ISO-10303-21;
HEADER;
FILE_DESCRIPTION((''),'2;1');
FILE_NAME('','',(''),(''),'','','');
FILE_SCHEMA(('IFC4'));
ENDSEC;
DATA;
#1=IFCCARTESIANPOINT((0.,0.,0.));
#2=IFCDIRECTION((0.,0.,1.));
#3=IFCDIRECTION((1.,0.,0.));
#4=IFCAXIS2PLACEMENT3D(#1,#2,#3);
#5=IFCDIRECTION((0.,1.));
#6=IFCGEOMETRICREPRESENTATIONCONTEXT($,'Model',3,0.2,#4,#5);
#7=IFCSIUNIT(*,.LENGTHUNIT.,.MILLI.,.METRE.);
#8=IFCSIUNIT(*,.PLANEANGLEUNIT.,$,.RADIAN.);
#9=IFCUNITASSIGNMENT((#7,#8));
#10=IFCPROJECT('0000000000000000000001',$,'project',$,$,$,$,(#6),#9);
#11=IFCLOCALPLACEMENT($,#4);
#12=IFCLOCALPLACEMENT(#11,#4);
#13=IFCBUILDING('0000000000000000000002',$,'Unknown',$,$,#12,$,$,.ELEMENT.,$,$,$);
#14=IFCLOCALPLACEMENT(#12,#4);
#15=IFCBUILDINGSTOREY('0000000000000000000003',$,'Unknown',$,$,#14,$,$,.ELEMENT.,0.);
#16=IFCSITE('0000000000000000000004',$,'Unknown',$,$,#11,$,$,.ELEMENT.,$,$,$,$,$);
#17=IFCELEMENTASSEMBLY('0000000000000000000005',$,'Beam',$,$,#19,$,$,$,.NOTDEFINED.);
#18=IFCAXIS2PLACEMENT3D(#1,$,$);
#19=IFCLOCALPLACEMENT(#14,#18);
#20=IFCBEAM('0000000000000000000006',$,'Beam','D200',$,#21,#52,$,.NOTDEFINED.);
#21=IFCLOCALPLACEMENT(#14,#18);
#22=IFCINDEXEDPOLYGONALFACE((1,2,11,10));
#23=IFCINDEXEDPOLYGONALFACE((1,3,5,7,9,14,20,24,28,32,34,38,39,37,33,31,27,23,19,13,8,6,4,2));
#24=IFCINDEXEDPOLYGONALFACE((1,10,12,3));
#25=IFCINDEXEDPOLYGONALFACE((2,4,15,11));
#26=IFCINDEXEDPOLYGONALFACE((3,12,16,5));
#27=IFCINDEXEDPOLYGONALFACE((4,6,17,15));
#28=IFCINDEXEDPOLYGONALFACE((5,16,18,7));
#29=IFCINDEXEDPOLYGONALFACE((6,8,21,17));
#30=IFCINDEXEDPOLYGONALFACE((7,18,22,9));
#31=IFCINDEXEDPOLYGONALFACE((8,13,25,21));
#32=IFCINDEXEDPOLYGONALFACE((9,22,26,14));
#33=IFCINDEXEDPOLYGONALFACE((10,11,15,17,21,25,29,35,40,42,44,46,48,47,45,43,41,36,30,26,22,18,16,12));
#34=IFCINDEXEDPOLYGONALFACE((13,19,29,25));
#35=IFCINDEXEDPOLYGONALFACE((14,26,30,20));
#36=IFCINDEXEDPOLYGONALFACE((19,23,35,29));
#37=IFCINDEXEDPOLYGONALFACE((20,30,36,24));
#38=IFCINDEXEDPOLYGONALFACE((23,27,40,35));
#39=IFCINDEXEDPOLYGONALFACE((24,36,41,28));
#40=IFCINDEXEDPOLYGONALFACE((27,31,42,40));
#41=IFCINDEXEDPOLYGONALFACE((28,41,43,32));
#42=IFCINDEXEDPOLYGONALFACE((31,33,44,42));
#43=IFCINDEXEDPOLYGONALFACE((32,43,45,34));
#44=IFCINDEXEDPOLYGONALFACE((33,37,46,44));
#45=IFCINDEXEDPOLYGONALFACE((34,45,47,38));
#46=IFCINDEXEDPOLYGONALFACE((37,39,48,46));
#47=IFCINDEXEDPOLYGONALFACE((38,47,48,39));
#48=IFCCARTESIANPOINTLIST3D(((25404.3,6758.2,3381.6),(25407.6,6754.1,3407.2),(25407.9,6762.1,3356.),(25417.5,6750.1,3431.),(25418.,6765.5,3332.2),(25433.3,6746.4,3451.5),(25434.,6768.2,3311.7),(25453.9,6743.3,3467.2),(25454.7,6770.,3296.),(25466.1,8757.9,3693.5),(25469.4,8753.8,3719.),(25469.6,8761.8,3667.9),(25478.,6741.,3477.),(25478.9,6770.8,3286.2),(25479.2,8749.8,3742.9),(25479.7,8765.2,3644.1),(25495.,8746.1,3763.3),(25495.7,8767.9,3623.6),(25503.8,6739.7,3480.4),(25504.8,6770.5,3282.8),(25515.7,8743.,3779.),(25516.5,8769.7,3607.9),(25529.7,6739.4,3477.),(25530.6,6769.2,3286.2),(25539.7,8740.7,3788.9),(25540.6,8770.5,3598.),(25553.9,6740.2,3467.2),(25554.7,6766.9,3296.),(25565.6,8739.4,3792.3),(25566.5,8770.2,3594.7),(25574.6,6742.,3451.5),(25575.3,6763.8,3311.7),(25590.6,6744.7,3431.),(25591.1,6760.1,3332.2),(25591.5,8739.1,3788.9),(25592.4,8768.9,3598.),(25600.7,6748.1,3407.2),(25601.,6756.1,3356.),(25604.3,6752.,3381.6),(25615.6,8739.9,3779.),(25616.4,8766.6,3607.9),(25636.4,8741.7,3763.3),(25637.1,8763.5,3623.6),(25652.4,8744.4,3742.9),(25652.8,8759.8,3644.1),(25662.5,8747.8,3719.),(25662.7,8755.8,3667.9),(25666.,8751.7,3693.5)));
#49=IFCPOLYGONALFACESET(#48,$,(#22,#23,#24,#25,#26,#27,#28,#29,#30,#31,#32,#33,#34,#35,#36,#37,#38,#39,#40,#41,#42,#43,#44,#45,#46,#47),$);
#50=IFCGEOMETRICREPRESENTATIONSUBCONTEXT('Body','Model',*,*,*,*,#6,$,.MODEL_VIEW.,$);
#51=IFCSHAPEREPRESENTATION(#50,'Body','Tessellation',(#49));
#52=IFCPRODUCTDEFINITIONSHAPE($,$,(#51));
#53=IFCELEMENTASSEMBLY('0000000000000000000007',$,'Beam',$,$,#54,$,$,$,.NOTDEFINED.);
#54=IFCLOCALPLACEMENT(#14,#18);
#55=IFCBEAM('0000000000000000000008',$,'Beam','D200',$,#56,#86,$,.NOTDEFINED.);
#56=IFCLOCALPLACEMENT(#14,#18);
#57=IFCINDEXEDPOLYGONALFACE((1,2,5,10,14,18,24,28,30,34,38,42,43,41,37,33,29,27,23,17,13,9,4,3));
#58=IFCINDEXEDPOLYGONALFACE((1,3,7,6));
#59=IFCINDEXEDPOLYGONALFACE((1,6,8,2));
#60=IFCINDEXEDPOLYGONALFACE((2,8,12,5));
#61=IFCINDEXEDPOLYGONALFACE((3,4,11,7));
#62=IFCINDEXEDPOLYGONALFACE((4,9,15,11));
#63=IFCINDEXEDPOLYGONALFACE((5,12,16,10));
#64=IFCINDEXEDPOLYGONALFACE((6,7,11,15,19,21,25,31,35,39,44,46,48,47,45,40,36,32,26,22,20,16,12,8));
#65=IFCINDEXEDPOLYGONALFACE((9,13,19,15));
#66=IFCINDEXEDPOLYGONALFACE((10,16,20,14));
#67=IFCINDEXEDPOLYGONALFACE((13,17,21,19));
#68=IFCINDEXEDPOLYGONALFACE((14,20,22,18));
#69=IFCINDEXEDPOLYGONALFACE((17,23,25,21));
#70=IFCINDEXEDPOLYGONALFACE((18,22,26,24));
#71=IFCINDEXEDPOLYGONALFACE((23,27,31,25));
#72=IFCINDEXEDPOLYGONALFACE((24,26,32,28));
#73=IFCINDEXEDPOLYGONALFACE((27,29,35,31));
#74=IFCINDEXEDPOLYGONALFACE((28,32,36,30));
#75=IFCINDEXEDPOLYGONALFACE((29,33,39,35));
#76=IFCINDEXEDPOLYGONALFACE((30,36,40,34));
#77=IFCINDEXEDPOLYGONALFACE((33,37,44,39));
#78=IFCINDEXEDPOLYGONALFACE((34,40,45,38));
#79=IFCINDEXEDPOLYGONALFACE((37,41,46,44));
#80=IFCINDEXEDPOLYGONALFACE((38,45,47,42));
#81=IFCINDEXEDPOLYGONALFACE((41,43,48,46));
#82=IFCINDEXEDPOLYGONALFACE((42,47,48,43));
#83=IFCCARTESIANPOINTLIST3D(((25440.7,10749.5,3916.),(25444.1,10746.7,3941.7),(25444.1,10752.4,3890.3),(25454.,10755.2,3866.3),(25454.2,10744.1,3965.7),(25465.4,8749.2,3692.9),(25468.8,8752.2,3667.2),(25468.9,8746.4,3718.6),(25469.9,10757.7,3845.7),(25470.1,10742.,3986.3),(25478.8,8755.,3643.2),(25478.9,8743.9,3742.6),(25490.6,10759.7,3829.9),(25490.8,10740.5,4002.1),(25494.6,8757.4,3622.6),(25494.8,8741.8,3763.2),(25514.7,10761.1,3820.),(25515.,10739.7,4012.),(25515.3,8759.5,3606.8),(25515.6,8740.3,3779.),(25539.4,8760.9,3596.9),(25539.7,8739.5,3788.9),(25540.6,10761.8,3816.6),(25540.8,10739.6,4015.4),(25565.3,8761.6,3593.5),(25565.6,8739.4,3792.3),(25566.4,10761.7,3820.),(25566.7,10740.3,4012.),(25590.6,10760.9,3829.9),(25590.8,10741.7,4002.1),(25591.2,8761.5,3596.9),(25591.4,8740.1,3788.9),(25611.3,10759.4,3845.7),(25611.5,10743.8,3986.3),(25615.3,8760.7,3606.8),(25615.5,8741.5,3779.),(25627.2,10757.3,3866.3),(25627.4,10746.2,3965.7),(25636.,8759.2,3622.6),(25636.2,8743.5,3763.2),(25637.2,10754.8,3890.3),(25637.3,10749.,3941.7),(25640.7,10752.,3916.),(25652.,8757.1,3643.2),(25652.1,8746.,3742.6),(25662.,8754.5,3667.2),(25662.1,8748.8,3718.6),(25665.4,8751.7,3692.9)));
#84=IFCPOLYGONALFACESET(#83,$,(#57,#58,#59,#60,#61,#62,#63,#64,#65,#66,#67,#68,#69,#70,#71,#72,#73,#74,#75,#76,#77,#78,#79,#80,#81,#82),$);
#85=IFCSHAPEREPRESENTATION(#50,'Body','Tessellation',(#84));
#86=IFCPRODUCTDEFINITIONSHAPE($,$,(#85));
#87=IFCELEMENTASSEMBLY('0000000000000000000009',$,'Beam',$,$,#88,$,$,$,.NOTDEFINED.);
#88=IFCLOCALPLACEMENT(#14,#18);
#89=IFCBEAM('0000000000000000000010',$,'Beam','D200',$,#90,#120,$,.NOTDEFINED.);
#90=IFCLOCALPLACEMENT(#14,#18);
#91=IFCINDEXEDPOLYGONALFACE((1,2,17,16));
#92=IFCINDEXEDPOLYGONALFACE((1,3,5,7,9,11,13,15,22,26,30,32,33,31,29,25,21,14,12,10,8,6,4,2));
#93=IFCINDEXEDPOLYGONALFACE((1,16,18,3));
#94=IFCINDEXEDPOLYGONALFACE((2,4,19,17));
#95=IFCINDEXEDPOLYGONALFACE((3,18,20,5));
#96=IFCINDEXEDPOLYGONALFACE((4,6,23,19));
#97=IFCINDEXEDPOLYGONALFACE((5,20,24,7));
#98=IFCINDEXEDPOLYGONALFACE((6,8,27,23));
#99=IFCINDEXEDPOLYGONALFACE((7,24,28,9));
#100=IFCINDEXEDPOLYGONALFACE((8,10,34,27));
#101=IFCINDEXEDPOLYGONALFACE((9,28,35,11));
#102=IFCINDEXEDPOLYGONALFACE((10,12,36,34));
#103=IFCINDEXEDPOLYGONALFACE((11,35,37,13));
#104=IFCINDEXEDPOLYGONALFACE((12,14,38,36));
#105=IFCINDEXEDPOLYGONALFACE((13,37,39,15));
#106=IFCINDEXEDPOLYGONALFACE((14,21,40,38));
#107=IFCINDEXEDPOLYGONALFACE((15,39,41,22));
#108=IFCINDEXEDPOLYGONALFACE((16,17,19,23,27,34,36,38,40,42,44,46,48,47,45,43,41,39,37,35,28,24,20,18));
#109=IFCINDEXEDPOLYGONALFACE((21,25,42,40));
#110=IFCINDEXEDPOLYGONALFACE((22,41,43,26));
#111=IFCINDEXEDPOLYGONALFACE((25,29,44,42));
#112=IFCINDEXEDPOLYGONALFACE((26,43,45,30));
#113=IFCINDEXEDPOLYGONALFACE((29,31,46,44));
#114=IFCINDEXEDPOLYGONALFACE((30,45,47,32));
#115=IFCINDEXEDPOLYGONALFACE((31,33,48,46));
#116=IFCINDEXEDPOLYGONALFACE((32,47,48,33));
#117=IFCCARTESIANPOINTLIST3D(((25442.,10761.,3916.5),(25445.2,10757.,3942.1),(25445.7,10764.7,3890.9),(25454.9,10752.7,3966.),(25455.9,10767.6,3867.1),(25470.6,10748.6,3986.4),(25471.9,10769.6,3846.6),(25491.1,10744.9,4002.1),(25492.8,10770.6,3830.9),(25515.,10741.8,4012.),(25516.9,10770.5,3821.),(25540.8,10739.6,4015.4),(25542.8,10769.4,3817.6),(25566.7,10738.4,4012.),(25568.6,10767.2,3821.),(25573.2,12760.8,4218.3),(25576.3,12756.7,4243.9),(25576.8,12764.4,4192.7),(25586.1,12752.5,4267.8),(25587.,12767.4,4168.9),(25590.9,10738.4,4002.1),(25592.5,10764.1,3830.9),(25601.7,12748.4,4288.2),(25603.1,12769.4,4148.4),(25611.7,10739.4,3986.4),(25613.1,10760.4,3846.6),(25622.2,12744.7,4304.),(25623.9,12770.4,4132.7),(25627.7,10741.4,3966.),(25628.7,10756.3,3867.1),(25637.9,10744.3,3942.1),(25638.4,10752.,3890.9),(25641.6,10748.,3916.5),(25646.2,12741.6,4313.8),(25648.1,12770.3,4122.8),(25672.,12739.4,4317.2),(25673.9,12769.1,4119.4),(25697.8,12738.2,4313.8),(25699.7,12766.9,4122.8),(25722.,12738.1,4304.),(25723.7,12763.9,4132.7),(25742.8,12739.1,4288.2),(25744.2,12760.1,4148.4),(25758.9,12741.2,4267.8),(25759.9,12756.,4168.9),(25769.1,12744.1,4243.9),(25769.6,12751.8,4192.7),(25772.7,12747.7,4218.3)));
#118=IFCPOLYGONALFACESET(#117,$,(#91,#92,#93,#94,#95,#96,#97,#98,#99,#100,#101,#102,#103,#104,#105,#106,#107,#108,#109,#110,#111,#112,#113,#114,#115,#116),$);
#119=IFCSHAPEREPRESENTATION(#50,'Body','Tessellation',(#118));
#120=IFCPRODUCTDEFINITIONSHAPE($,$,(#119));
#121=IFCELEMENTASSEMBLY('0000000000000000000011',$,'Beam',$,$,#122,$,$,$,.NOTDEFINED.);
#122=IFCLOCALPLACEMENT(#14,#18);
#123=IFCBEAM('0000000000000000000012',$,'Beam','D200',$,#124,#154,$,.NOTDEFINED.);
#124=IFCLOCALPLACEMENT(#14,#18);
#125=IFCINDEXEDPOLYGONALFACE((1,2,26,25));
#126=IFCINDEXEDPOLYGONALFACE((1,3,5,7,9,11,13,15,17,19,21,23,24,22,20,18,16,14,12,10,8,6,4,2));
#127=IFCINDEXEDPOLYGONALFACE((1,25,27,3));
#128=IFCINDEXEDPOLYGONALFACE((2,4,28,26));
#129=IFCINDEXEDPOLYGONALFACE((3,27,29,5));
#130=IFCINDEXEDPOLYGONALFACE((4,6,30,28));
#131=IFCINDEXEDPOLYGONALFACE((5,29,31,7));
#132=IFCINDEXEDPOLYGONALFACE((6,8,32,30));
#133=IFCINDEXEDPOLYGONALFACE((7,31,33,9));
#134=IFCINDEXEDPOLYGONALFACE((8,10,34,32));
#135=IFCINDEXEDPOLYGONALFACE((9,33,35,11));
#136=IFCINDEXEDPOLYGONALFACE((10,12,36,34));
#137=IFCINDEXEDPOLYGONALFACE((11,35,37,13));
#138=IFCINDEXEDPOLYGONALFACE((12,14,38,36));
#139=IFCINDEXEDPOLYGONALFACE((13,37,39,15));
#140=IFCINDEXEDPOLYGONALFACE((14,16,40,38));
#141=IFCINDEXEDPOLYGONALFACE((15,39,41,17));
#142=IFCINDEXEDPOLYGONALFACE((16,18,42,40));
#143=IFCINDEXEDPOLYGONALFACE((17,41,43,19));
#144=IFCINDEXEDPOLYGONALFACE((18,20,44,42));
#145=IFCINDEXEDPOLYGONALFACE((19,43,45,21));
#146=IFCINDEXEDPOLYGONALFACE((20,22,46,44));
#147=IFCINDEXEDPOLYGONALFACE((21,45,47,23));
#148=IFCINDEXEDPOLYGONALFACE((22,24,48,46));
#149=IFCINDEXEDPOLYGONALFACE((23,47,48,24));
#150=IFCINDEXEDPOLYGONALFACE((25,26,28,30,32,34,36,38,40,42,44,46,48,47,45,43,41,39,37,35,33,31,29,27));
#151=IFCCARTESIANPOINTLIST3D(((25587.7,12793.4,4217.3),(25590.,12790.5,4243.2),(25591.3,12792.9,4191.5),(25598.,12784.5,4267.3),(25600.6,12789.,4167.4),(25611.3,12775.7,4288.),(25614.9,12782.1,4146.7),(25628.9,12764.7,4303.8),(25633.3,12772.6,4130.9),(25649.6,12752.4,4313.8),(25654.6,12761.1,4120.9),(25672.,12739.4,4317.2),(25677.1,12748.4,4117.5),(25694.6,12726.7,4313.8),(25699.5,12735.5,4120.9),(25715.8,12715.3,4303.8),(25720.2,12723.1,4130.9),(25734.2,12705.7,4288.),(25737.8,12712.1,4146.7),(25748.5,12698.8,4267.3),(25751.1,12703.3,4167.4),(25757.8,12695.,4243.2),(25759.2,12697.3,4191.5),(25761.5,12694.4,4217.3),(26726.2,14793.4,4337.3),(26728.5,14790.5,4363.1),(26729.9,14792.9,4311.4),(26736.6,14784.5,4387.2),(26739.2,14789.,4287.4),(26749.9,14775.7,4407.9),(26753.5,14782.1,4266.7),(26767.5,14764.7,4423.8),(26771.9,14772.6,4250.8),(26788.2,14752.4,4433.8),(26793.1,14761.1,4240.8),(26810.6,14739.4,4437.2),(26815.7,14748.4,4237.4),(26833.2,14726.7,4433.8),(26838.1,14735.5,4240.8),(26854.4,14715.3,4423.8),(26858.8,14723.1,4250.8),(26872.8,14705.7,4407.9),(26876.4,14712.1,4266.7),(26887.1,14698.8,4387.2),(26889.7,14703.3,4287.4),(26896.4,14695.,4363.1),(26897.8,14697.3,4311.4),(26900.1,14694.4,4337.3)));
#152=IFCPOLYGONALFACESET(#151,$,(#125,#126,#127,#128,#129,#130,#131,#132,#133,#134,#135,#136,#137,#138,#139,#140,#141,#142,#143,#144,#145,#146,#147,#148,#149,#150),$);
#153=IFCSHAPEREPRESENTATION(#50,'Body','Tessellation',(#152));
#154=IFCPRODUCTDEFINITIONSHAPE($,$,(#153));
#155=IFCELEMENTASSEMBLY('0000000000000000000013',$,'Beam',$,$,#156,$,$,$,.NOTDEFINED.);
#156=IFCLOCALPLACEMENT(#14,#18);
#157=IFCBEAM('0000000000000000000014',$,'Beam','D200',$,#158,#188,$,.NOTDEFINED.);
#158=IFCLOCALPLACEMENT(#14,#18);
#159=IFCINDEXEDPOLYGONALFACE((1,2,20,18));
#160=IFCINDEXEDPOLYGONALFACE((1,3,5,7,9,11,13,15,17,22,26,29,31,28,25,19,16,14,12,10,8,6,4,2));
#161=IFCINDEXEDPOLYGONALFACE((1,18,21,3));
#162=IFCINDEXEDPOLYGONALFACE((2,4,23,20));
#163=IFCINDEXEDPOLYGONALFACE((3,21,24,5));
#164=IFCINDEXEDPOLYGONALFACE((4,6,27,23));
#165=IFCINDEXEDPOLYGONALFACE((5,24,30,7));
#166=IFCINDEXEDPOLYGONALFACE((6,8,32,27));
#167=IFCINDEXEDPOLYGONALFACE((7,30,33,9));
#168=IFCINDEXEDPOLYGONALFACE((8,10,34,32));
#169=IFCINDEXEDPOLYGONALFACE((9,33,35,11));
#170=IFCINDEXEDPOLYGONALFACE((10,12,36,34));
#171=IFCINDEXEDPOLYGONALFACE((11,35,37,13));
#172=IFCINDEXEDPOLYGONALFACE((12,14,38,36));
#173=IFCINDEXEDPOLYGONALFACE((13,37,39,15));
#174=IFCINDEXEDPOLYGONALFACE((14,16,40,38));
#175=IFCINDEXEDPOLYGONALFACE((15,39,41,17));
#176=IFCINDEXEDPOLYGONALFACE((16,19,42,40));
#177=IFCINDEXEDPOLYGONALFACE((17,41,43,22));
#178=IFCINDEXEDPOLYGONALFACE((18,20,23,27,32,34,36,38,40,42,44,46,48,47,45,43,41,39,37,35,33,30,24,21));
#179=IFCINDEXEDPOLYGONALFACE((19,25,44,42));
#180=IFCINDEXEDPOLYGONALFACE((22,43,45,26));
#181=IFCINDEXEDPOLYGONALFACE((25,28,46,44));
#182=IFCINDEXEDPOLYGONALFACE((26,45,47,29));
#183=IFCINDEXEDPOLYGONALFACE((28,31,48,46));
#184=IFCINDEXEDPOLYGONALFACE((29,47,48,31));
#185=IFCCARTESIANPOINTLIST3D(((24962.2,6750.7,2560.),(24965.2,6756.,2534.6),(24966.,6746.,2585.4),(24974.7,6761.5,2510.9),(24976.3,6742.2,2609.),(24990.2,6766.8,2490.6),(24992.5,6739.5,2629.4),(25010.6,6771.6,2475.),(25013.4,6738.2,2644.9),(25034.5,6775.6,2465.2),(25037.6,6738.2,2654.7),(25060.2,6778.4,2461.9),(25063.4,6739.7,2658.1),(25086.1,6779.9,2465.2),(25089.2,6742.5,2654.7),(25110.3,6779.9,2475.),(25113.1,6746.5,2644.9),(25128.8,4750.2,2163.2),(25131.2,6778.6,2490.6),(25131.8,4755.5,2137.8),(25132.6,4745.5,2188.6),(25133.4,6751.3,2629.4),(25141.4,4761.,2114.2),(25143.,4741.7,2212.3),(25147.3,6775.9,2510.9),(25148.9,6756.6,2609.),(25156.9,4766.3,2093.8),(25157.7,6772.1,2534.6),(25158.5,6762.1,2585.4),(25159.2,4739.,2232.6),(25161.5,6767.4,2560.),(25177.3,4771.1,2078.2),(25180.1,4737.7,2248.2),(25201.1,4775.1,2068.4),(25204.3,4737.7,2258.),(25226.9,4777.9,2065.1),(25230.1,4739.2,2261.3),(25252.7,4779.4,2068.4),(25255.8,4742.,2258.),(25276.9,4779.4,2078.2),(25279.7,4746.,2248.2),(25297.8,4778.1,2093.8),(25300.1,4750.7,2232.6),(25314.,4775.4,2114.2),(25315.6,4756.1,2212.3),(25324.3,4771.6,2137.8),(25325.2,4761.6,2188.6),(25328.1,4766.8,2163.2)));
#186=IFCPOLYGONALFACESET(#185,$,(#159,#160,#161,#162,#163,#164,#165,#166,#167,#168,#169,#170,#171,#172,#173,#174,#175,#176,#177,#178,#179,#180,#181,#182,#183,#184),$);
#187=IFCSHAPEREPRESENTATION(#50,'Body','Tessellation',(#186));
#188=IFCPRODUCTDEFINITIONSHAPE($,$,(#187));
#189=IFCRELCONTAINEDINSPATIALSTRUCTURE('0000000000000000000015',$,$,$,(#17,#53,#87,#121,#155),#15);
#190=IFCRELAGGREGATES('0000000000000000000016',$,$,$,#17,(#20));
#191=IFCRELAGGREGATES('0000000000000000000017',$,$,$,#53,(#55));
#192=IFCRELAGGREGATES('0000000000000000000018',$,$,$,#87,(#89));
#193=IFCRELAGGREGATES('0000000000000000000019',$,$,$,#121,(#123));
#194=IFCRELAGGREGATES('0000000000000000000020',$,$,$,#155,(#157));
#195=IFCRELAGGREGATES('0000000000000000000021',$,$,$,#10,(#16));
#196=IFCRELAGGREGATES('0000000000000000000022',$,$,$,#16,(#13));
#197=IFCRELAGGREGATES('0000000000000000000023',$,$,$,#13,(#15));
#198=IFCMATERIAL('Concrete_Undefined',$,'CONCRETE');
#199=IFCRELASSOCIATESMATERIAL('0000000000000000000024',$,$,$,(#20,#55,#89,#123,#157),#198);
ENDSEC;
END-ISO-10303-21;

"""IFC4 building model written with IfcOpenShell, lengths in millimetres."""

from ifc_helpers import new_model, si_unit, direction, frame, origin_with_axes, place, context, subcontext, project, spatial, line, indexed_curve, outline, extrude, material, element, aggregate, save


model = new_model("IFC4")

# Units and contexts
model_context = context("Model", 3, precision=0.2, world=origin_with_axes(), true_north=direction((0.0, 1.0)))
body_context = subcontext(model_context, "Body", "Model", "MODEL_VIEW")
ifc_project = project(units=[si_unit("LENGTHUNIT", "METRE", prefix="MILLI"), si_unit("PLANEANGLEUNIT", "RADIAN")], contexts=[model_context])

# Site, building, storey
site_placement = place(None, origin_with_axes())
site = spatial("IfcSite", under=ifc_project, at=site_placement, Name="Unknown", CompositionType="ELEMENT")
building_placement = place(site_placement, origin_with_axes())
building = spatial("IfcBuilding", under=site, at=building_placement, Name="Unknown", CompositionType="ELEMENT")
storey_placement = place(building_placement, origin_with_axes())
storey = spatial("IfcBuildingStorey", under=building, at=storey_placement, Name="Unknown", CompositionType="ELEMENT", Elevation=0.0)

# Shared definitions
ifc_material = material(Name="Concrete_Undefined", Category="CONCRETE")

# Element assemblies, beams
assembly_1_placement = place(storey_placement, frame((25566.0, 8754.8, 3693.5), z_axis=(-0.999524, 0.030862, 0.0), x_axis=(-0.030494, -0.987596, -0.154025)))
assembly_1 = element("IfcElementAssembly", 1, at=assembly_1_placement, inside=storey, Name="Beam", PredefinedType="NOTDEFINED")
beam_1_placement = place(assembly_1_placement, origin_with_axes())
beam_1 = element("IfcBeam", 2, at=beam_1_placement, material=ifc_material, Name="Beam", Description="D200", PredefinedType="NOTDEFINED", context=body_context, shape_type="SolidModel", body=[
    extrude(outline(indexed_curve([(100.0, 0.0), (96.6, 25.9), (86.6, 50.0), (70.7, 70.7), (50.0, 86.6), (25.9, 96.6), (0.0, 100.0), (-25.9, 96.6), (-50.0, 86.6), (-70.7, 70.7), (-86.6, 50.0), (-96.6, 25.9), (-100.0, 0.0), (-96.6, -25.9), (-86.6, -50.0), (-70.7, -70.7), (-50.0, -86.6), (-25.9, -96.6), (0.0, -100.0), (25.9, -96.6), (50.0, -86.6), (70.7, -70.7), (86.6, -50.0), (96.6, -25.9)], segments=[line(1, 2, 3, 4, 5, 6, 7, 8, 9, 10, 11, 12, 13, 14, 15, 16, 17, 18, 19, 20, 21, 22, 23, 24, 1)])), frame((0.0, 0.0, 0.0), z_axis=(-1.0, 0.0, 0.0), x_axis=(0.0, 0.0, 1.0)), (0.0, 0.0, -1.0), 2024.8),
])
aggregate(assembly_1, [beam_1])
assembly_2_placement = place(storey_placement, frame((25540.7, 10750.7, 3916.0), z_axis=(-0.999924, -0.012364, 0.0), x_axis=(0.012288, -0.993761, -0.110851)))
assembly_2 = element("IfcElementAssembly", 3, at=assembly_2_placement, inside=storey, Name="Beam", PredefinedType="NOTDEFINED")
beam_2_placement = place(assembly_2_placement, origin_with_axes())
beam_2 = element("IfcBeam", 4, at=beam_2_placement, material=ifc_material, Name="Beam", Description="D200", PredefinedType="NOTDEFINED", context=body_context, shape_type="SolidModel", body=[
    extrude(outline(indexed_curve([(100.0, 0.0), (96.6, 25.9), (86.6, 50.0), (70.7, 70.7), (50.0, 86.6), (25.9, 96.6), (0.0, 100.0), (-25.9, 96.6), (-50.0, 86.6), (-70.7, 70.7), (-86.6, 50.0), (-96.6, 25.9), (-100.0, 0.0), (-96.6, -25.9), (-86.6, -50.0), (-70.7, -70.7), (-50.0, -86.6), (-25.9, -96.6), (0.0, -100.0), (25.9, -96.6), (50.0, -86.6), (70.7, -70.7), (86.6, -50.0), (96.6, -25.9)], segments=[line(1, 2, 3, 4, 5, 6, 7, 8, 9, 10, 11, 12, 13, 14, 15, 16, 17, 18, 19, 20, 21, 22, 23, 24, 1)])), frame((0.0, 0.0, 0.0), z_axis=(-1.0, 0.0, 0.0), x_axis=(0.0, 0.0, 1.0)), (0.0, 0.0, -1.0), 2012.8),
])
aggregate(assembly_2, [beam_2])
assembly_3_placement = place(storey_placement, frame((25673.0, 12754.3, 4218.3), z_axis=(-0.997856, 0.065442, 0.0), x_axis=(-0.064712, -0.986729, -0.148924)))
assembly_3 = element("IfcElementAssembly", 5, at=assembly_3_placement, inside=storey, Name="Beam", PredefinedType="NOTDEFINED")
beam_3_placement = place(assembly_3_placement, origin_with_axes())
beam_3 = element("IfcBeam", 6, at=beam_3_placement, material=ifc_material, Name="Beam", Description="D200", PredefinedType="NOTDEFINED", context=body_context, shape_type="SolidModel", body=[
    extrude(outline(indexed_curve([(100.0, 0.0), (96.6, 25.9), (86.6, 50.0), (70.7, 70.7), (50.0, 86.6), (25.9, 96.6), (0.0, 100.0), (-25.9, 96.6), (-50.0, 86.6), (-70.7, 70.7), (-86.6, 50.0), (-96.6, 25.9), (-100.0, 0.0), (-96.6, -25.9), (-86.6, -50.0), (-70.7, -70.7), (-50.0, -86.6), (-25.9, -96.6), (0.0, -100.0), (25.9, -96.6), (50.0, -86.6), (70.7, -70.7), (86.6, -50.0), (96.6, -25.9)], segments=[line(1, 2, 3, 4, 5, 6, 7, 8, 9, 10, 11, 12, 13, 14, 15, 16, 17, 18, 19, 20, 21, 22, 23, 24, 1)])), frame((0.0, 0.0, 0.0), z_axis=(-1.0, 0.0, 0.0), x_axis=(0.0, 0.0, 1.0)), (0.0, 0.0, -1.0), 2026.7),
])
aggregate(assembly_3, [beam_3])
assembly_4_placement = place(storey_placement, frame((26813.2, 14743.9, 4337.3), z_axis=(-0.869041, 0.494741, 0.0), x_axis=(-0.49407, -0.867863, -0.052049)))
assembly_4 = element("IfcElementAssembly", 7, at=assembly_4_placement, inside=storey, Name="Beam", PredefinedType="NOTDEFINED")
beam_4_placement = place(assembly_4_placement, origin_with_axes())
beam_4 = element("IfcBeam", 8, at=beam_4_placement, material=ifc_material, Name="Beam", Description="D200", PredefinedType="NOTDEFINED", context=body_context, shape_type="SolidModel", body=[
    extrude(outline(indexed_curve([(100.0, 0.0), (96.6, 25.9), (86.6, 50.0), (70.7, 70.7), (50.0, 86.6), (25.9, 96.6), (0.0, 100.0), (-25.9, 96.6), (-50.0, 86.6), (-70.7, 70.7), (-86.6, 50.0), (-96.6, 25.9), (-100.0, 0.0), (-96.6, -25.9), (-86.6, -50.0), (-70.7, -70.7), (-50.0, -86.6), (-25.9, -96.6), (0.0, -100.0), (25.9, -96.6), (50.0, -86.6), (70.7, -70.7), (86.6, -50.0), (96.6, -25.9)], segments=[line(1, 2, 3, 4, 5, 6, 7, 8, 9, 10, 11, 12, 13, 14, 15, 16, 17, 18, 19, 20, 21, 22, 23, 24, 1)])), frame((0.0, 0.0, 0.0), z_axis=(-1.0, 0.0, 0.0), x_axis=(0.0, 0.0, 1.0)), (0.0, 0.0, -1.0), 2304.5),
])
aggregate(assembly_4, [beam_4])
assembly_5_placement = place(storey_placement, frame((25061.8, 6759.1, 2560.0), z_axis=(-0.996548, -0.08302, 0.0), x_axis=(0.081444, -0.977633, -0.193907)))
assembly_5 = element("IfcElementAssembly", 9, at=assembly_5_placement, inside=storey, Name="Beam", PredefinedType="NOTDEFINED")
beam_5_placement = place(assembly_5_placement, origin_with_axes())
beam_5 = element("IfcBeam", 10, at=beam_5_placement, material=ifc_material, Name="Beam", Description="D200", PredefinedType="NOTDEFINED", context=body_context, shape_type="SolidModel", body=[
    extrude(outline(indexed_curve([(100.0, 0.0), (96.6, 25.9), (86.6, 50.0), (70.7, 70.7), (50.0, 86.6), (25.9, 96.6), (0.0, 100.0), (-25.9, 96.6), (-50.0, 86.6), (-70.7, 70.7), (-86.6, 50.0), (-96.6, 25.9), (-100.0, 0.0), (-96.6, -25.9), (-86.6, -50.0), (-70.7, -70.7), (-50.0, -86.6), (-25.9, -96.6), (0.0, -100.0), (25.9, -96.6), (50.0, -86.6), (70.7, -70.7), (86.6, -50.0), (96.6, -25.9)], segments=[line(1, 2, 3, 4, 5, 6, 7, 8, 9, 10, 11, 12, 13, 14, 15, 16, 17, 18, 19, 20, 21, 22, 23, 24, 1)])), frame((0.0, 0.0, 0.0), z_axis=(-1.0, 0.0, 0.0), x_axis=(0.0, 0.0, 1.0)), (0.0, 0.0, -1.0), 2046.3),
])
aggregate(assembly_5, [beam_5])

save(model, "model.ifc")
